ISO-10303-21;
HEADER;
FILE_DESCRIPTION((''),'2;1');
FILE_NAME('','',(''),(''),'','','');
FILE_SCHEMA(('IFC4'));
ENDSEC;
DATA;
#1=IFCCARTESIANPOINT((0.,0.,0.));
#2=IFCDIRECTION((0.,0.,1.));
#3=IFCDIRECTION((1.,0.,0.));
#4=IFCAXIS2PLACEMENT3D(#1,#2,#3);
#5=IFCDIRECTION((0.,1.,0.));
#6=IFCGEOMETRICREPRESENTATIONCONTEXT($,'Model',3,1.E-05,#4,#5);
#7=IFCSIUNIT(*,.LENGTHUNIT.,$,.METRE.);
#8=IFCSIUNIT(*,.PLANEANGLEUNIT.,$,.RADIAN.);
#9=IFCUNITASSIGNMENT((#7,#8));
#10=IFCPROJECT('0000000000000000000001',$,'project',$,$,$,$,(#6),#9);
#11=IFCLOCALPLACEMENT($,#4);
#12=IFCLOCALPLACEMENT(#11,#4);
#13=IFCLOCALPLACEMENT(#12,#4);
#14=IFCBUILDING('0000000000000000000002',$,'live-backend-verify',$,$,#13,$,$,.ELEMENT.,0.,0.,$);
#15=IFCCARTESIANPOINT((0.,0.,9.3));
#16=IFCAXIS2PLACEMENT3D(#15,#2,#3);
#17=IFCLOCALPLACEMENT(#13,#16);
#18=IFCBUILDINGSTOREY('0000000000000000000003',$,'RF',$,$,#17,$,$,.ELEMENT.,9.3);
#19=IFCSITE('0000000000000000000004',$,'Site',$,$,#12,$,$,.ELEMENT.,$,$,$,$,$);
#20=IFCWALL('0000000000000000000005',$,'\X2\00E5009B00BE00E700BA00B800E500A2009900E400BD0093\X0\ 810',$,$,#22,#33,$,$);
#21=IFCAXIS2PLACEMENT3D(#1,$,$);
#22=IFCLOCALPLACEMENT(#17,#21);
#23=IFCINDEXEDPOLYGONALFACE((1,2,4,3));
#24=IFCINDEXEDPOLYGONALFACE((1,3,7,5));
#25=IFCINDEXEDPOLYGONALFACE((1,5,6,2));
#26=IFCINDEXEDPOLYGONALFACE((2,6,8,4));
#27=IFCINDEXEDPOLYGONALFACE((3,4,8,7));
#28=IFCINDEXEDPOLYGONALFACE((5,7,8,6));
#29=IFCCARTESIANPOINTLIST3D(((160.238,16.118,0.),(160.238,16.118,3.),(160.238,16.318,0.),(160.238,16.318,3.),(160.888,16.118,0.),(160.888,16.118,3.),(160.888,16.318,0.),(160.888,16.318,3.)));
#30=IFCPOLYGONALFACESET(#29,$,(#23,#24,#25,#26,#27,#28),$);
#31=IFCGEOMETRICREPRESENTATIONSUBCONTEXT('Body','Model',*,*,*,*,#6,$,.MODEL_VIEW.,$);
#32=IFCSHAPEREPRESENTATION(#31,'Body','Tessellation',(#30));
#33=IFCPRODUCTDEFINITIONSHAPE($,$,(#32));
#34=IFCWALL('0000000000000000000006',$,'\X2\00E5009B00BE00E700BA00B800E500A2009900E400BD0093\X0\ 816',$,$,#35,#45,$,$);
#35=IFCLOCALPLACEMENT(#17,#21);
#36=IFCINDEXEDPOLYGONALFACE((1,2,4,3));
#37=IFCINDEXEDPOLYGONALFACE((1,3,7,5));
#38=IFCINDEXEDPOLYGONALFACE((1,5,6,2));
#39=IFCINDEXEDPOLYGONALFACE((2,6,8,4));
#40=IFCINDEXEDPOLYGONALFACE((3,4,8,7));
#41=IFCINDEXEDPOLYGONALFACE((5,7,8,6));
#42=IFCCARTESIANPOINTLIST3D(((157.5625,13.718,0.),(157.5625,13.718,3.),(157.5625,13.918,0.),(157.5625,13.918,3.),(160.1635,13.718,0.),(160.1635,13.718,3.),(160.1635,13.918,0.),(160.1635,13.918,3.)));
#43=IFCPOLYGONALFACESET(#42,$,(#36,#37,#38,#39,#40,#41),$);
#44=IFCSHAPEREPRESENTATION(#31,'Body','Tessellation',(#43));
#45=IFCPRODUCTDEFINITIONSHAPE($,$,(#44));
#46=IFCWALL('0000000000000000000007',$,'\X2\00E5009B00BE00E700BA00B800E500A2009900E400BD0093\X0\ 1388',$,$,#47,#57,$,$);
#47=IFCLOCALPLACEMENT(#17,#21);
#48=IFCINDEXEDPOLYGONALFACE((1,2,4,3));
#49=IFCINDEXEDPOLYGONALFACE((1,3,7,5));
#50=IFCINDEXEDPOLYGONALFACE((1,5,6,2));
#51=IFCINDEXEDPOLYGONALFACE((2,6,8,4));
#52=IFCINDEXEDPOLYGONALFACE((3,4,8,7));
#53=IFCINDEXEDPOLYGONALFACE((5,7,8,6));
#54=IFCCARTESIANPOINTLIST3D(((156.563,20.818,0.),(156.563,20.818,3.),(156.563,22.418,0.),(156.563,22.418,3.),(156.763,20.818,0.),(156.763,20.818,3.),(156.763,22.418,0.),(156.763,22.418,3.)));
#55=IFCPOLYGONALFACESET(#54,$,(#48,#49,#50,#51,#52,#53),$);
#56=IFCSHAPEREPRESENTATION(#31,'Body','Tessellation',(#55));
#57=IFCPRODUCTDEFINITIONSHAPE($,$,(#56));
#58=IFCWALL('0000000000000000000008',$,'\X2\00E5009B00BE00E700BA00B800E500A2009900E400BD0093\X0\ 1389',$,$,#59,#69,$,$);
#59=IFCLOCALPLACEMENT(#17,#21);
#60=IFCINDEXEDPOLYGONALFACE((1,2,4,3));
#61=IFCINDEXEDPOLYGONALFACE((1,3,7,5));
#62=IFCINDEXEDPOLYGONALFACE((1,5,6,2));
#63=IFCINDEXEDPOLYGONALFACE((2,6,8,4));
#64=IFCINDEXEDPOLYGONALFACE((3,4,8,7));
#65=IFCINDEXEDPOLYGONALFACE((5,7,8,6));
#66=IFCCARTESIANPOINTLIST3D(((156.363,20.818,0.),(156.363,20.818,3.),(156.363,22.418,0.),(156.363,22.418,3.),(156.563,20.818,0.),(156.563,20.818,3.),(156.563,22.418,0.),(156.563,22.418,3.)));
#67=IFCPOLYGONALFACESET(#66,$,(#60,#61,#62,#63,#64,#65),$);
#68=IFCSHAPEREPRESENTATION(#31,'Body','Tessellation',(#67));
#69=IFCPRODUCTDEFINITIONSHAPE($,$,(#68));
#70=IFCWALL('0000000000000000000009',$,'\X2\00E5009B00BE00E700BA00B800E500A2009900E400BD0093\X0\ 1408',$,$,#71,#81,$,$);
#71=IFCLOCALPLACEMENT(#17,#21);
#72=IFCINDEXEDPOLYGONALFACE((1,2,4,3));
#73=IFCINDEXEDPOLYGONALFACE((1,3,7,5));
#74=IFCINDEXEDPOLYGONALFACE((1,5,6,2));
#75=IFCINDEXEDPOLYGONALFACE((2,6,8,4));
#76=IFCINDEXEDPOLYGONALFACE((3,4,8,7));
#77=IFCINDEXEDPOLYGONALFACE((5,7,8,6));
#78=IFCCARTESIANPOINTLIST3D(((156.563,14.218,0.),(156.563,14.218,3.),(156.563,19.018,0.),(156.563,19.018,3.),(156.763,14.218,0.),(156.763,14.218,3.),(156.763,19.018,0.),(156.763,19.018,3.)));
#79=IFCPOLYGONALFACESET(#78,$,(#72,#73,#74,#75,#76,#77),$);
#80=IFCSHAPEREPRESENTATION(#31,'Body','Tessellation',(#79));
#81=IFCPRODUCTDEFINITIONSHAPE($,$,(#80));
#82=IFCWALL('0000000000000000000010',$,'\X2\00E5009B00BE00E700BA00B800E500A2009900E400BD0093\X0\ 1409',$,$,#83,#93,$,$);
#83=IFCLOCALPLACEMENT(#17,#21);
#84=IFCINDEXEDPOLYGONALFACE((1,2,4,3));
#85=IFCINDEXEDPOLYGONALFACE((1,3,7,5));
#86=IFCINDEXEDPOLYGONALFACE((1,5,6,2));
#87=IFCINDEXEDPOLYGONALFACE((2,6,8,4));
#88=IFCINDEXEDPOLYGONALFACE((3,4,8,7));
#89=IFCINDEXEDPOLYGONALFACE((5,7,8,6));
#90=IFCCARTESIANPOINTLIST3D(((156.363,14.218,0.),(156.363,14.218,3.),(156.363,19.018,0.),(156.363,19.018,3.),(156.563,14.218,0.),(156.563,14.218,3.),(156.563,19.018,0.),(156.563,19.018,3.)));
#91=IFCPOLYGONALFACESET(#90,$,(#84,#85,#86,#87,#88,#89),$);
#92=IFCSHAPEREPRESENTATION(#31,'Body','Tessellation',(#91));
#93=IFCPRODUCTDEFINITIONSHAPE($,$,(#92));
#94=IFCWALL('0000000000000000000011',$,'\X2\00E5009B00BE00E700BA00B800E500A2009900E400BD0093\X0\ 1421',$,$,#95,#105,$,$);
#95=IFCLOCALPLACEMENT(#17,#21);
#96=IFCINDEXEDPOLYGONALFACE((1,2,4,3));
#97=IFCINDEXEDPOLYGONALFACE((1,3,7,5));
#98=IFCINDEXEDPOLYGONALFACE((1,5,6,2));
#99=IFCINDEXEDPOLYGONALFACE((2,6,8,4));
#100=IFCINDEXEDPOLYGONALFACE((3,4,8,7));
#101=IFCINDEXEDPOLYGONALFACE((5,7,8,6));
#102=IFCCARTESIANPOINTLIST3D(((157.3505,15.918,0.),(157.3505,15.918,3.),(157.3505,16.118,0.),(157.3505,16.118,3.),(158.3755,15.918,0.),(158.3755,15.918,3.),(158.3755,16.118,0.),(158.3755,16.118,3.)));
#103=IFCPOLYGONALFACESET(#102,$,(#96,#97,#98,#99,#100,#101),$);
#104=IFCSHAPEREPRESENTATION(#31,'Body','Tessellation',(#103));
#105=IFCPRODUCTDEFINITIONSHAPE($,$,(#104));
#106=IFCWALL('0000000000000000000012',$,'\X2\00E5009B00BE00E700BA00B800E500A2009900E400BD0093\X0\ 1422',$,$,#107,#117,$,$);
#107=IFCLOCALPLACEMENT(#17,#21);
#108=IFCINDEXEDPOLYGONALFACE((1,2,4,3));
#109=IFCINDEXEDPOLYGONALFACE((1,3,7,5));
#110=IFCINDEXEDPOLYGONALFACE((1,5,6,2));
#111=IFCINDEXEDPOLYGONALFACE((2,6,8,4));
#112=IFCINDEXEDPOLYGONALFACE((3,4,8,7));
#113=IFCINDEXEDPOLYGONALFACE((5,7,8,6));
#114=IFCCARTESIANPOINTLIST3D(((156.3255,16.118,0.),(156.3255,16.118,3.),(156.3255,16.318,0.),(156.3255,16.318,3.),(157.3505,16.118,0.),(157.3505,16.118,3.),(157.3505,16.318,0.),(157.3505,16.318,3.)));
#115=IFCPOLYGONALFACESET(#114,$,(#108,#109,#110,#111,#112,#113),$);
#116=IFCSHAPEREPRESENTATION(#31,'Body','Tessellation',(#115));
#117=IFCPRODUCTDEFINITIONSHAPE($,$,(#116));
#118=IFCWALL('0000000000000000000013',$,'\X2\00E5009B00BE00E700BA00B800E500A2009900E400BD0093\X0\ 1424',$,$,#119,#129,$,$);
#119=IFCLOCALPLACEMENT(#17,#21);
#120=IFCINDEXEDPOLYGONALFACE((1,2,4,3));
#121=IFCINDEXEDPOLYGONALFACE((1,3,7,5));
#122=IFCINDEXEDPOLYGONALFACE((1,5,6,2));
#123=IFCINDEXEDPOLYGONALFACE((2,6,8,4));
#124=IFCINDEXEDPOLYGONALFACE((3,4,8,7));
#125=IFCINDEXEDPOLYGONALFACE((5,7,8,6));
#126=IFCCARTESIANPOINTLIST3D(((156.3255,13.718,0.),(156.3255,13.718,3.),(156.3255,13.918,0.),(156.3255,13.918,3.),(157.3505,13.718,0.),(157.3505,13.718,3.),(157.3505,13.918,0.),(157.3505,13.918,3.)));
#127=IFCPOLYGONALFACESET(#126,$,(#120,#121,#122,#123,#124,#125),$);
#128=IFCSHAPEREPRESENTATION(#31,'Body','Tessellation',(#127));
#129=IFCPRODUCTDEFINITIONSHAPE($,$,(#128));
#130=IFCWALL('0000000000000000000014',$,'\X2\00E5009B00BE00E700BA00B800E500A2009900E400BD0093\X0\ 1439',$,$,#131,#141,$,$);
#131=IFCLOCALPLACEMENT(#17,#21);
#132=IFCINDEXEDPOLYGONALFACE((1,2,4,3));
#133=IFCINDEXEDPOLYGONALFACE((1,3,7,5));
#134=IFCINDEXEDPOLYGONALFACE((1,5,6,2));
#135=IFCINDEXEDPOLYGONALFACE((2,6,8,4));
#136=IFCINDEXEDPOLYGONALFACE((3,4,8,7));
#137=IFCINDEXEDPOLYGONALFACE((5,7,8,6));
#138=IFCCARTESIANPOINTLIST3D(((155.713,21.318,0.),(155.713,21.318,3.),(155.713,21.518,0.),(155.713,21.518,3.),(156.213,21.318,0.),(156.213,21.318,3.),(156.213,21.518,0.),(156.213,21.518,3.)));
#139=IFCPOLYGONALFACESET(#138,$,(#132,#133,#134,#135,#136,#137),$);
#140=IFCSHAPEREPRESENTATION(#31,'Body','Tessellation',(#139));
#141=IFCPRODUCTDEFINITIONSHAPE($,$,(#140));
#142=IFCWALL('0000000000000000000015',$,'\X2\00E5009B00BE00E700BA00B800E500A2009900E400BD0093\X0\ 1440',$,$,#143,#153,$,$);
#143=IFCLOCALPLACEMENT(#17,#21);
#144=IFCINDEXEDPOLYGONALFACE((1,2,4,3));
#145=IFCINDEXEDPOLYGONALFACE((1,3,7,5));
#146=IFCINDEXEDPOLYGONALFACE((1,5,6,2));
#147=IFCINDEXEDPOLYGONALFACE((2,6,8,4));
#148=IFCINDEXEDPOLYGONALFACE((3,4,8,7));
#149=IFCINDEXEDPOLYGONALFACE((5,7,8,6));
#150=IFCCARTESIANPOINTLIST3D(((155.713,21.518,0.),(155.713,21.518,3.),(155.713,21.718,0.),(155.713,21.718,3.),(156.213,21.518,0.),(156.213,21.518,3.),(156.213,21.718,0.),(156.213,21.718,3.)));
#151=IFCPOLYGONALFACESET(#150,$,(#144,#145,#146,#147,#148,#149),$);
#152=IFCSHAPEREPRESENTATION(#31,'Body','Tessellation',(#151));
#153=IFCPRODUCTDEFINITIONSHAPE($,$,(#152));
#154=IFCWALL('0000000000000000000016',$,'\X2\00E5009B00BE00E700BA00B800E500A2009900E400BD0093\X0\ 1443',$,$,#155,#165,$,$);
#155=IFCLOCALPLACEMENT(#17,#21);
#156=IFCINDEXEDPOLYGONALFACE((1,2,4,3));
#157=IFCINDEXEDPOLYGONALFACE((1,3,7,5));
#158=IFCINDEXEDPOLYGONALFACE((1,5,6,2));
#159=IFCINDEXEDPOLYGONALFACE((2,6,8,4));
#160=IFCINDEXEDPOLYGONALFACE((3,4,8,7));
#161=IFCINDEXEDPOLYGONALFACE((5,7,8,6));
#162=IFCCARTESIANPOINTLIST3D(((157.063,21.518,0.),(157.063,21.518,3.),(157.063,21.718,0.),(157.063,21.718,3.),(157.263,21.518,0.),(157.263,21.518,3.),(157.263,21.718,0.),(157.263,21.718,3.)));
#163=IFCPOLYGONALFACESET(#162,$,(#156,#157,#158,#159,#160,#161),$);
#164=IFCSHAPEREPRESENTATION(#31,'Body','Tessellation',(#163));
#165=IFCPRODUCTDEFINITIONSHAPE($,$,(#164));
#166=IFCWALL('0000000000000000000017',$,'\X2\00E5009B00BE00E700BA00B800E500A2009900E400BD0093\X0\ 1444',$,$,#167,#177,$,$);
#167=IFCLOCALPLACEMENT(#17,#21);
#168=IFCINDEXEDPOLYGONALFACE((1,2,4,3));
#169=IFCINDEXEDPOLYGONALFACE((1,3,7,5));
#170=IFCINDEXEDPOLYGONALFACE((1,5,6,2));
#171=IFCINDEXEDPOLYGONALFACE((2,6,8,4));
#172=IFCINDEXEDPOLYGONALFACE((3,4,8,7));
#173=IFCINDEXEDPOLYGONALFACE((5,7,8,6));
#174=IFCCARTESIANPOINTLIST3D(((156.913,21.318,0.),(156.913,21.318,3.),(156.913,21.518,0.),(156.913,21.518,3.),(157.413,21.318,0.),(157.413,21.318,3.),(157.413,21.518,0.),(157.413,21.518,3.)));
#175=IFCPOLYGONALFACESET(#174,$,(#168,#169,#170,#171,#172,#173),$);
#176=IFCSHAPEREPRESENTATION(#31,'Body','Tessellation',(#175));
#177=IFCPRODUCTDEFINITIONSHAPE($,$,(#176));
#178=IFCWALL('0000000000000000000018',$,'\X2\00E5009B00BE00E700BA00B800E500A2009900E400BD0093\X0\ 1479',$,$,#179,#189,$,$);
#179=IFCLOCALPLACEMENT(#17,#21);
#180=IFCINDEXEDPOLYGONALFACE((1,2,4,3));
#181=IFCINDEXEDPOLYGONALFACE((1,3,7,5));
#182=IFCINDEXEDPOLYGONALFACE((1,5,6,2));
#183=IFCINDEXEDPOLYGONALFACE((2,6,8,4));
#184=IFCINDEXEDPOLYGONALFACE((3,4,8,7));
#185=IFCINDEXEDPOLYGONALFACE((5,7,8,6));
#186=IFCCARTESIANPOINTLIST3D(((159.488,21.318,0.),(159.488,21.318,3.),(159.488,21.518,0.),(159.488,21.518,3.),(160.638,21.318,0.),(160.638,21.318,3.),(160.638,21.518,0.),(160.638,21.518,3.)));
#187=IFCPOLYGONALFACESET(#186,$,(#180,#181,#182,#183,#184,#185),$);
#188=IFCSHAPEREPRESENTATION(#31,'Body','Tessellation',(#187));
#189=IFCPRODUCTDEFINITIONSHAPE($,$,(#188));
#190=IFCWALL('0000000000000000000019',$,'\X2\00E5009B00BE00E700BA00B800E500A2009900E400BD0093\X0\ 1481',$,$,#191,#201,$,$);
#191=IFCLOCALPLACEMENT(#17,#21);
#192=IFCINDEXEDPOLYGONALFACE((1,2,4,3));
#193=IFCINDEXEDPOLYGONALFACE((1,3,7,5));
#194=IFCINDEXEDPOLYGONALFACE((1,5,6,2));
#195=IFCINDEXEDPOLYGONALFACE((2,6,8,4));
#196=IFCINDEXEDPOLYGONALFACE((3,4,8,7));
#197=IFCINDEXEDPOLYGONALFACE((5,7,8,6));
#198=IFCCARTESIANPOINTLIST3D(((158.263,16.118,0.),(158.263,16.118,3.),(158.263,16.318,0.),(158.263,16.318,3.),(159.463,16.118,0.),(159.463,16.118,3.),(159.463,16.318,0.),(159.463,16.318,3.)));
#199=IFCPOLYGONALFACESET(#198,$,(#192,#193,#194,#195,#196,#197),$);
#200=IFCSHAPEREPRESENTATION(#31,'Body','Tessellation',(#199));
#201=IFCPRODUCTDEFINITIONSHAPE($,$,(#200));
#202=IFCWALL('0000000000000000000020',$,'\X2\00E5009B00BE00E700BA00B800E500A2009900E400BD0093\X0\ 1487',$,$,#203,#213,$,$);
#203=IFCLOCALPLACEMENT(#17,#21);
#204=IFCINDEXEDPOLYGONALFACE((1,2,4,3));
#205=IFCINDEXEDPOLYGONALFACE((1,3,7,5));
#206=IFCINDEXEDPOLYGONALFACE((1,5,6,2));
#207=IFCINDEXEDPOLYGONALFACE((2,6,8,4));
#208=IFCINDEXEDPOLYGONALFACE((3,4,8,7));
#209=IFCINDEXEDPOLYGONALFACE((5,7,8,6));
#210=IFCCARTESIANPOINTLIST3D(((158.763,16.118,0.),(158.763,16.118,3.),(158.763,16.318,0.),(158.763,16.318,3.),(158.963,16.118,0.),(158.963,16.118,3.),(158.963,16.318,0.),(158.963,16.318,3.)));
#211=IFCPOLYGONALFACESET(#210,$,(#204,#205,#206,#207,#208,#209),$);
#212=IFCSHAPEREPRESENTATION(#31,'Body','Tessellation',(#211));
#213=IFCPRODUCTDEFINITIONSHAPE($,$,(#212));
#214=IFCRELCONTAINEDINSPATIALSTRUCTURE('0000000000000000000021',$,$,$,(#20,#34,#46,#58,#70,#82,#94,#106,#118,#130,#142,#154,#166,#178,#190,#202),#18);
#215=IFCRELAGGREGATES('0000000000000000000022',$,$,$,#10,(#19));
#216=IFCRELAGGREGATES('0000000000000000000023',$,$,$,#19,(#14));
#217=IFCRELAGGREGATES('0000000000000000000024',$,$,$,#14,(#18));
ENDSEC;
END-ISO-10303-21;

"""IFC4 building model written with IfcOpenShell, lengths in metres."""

from ifc_helpers import new_model, si_unit, direction, frame, frame_2d, origin_with_axes, place, context, subcontext, project, spatial, rectangle, extrude, element, save


model = new_model("IFC4")

# Units and contexts
model_context = context("Model", 3, precision=1e-05, world=origin_with_axes(), true_north=direction((0.0, 1.0, 0.0)))
body_context = subcontext(model_context, "Body", "Model", "MODEL_VIEW")
ifc_project = project(units=[si_unit("LENGTHUNIT", "METRE"), si_unit("PLANEANGLEUNIT", "RADIAN")], contexts=[model_context])

# Site, building, storey
placement = place(None, origin_with_axes())
site_placement = place(placement, origin_with_axes())
site = spatial("IfcSite", under=ifc_project, at=site_placement, Name="Site", CompositionType="ELEMENT")
building_placement = place(site_placement, origin_with_axes())
building = spatial("IfcBuilding", under=site, at=building_placement, Name="live-backend-verify", CompositionType="ELEMENT", ElevationOfRefHeight=0.0, ElevationOfTerrain=0.0)
storey_placement = place(building_placement, frame((0.0, 0.0, 9.3), z_axis=(0.0, 0.0, 1.0), x_axis=(1.0, 0.0, 0.0)))
storey = spatial("IfcBuildingStorey", under=building, at=storey_placement, Name="RF", CompositionType="ELEMENT", Elevation=9.3)

# Walls
wall_1_placement = place(storey_placement, frame((160.563, 16.218, 0.0), z_axis=(0.0, 0.0, 1.0), x_axis=(1.0, 0.0, 0.0)))
element("IfcWall", 1, at=wall_1_placement, inside=storey, Name="å\u009b¾çº¸å¢\u0099ä½\u0093 810", context=body_context, shape_type="SweptSolid", body=[
    extrude(rectangle(XDim=0.65, YDim=0.2, at=frame_2d((0.0, 0.0), x_axis=(1.0, 0.0, 0.0))), frame((0.0, 0.0, 0.0), z_axis=(0.0, 0.0, 1.0)), (0.0, 0.0, 1.0), 3.0),
])
wall_2_placement = place(storey_placement, frame((158.863, 13.818, 0.0), z_axis=(0.0, 0.0, 1.0), x_axis=(1.0, 0.0, 0.0)))
element("IfcWall", 2, at=wall_2_placement, inside=storey, Name="å\u009b¾çº¸å¢\u0099ä½\u0093 816", context=body_context, shape_type="SweptSolid", body=[
    extrude(rectangle(XDim=2.601, YDim=0.2, at=frame_2d((0.0, 0.0), x_axis=(1.0, 0.0, 0.0))), frame((0.0, 0.0, 0.0), z_axis=(0.0, 0.0, 1.0)), (0.0, 0.0, 1.0), 3.0),
])
for number, where, z_axis, x_axis, name in (
    (3, (156.663, 21.618, 0.0), (0.0, 0.0, 1.0), (0.0, 1.0, 0.0), "å\u009b¾çº¸å¢\u0099ä½\u0093 1388"),
    (4, (156.463, 21.618, 0.0), (0.0, 0.0, 1.0), (0.0, 1.0, 0.0), "å\u009b¾çº¸å¢\u0099ä½\u0093 1389"),
):
    element("IfcWall", number, at=place(storey_placement, frame(where, z_axis=z_axis, x_axis=x_axis)), inside=storey, Name=name, context=body_context, shape_type="SweptSolid", body=[
        extrude(rectangle(XDim=1.6, YDim=0.2, at=frame_2d((0.0, 0.0), x_axis=(1.0, 0.0, 0.0))), frame((0.0, 0.0, 0.0), z_axis=(0.0, 0.0, 1.0)), (0.0, 0.0, 1.0), 3.0),
    ])
for number, where, z_axis, x_axis, name in (
    (5, (156.663, 16.618, 0.0), (0.0, 0.0, 1.0), (0.0, 1.0, 0.0), "å\u009b¾çº¸å¢\u0099ä½\u0093 1408"),
    (6, (156.463, 16.618, 0.0), (0.0, 0.0, 1.0), (0.0, 1.0, 0.0), "å\u009b¾çº¸å¢\u0099ä½\u0093 1409"),
):
    element("IfcWall", number, at=place(storey_placement, frame(where, z_axis=z_axis, x_axis=x_axis)), inside=storey, Name=name, context=body_context, shape_type="SweptSolid", body=[
        extrude(rectangle(XDim=4.8, YDim=0.2, at=frame_2d((0.0, 0.0), x_axis=(1.0, 0.0, 0.0))), frame((0.0, 0.0, 0.0), z_axis=(0.0, 0.0, 1.0)), (0.0, 0.0, 1.0), 3.0),
    ])
for number, where, z_axis, x_axis, name in (
    (7, (157.863, 16.018, 0.0), (0.0, 0.0, 1.0), (-1.0, 0.0, 0.0), "å\u009b¾çº¸å¢\u0099ä½\u0093 1421"),
    (8, (156.838, 16.218, 0.0), (0.0, 0.0, 1.0), (1.0, 0.0, 0.0), "å\u009b¾çº¸å¢\u0099ä½\u0093 1422"),
    (9, (156.838, 13.818, 0.0), (0.0, 0.0, 1.0), (1.0, 0.0, 0.0), "å\u009b¾çº¸å¢\u0099ä½\u0093 1424"),
):
    element("IfcWall", number, at=place(storey_placement, frame(where, z_axis=z_axis, x_axis=x_axis)), inside=storey, Name=name, context=body_context, shape_type="SweptSolid", body=[
        extrude(rectangle(XDim=1.025, YDim=0.2, at=frame_2d((0.0, 0.0), x_axis=(1.0, 0.0, 0.0))), frame((0.0, 0.0, 0.0), z_axis=(0.0, 0.0, 1.0)), (0.0, 0.0, 1.0), 3.0),
    ])
for number, where, z_axis, x_axis, name in (
    (10, (155.963, 21.418, 0.0), (0.0, 0.0, 1.0), (1.0, 0.0, 0.0), "å\u009b¾çº¸å¢\u0099ä½\u0093 1439"),
    (11, (155.963, 21.618, 0.0), (0.0, 0.0, 1.0), (1.0, 0.0, 0.0), "å\u009b¾çº¸å¢\u0099ä½\u0093 1440"),
):
    element("IfcWall", number, at=place(storey_placement, frame(where, z_axis=z_axis, x_axis=x_axis)), inside=storey, Name=name, context=body_context, shape_type="SweptSolid", body=[
        extrude(rectangle(XDim=0.5, YDim=0.2, at=frame_2d((0.0, 0.0), x_axis=(1.0, 0.0, 0.0))), frame((0.0, 0.0, 0.0), z_axis=(0.0, 0.0, 1.0)), (0.0, 0.0, 1.0), 3.0),
    ])
wall_3_placement = place(storey_placement, frame((157.163, 21.618, 0.0), z_axis=(0.0, 0.0, 1.0), x_axis=(0.0, -1.0, 0.0)))
element("IfcWall", 12, at=wall_3_placement, inside=storey, Name="å\u009b¾çº¸å¢\u0099ä½\u0093 1443", context=body_context, shape_type="SweptSolid", body=[
    extrude(rectangle(XDim=0.2, YDim=0.2, at=frame_2d((0.0, 0.0), x_axis=(1.0, 0.0, 0.0))), frame((0.0, 0.0, 0.0), z_axis=(0.0, 0.0, 1.0)), (0.0, 0.0, 1.0), 3.0),
])
wall_4_placement = place(storey_placement, frame((157.163, 21.418, 0.0), z_axis=(0.0, 0.0, 1.0), x_axis=(-1.0, 0.0, 0.0)))
element("IfcWall", 13, at=wall_4_placement, inside=storey, Name="å\u009b¾çº¸å¢\u0099ä½\u0093 1444", context=body_context, shape_type="SweptSolid", body=[
    extrude(rectangle(XDim=0.5, YDim=0.2, at=frame_2d((0.0, 0.0), x_axis=(1.0, 0.0, 0.0))), frame((0.0, 0.0, 0.0), z_axis=(0.0, 0.0, 1.0)), (0.0, 0.0, 1.0), 3.0),
])
wall_5_placement = place(storey_placement, frame((160.063, 21.418, 0.0), z_axis=(0.0, 0.0, 1.0), x_axis=(-1.0, 0.0, 0.0)))
element("IfcWall", 14, at=wall_5_placement, inside=storey, Name="å\u009b¾çº¸å¢\u0099ä½\u0093 1479", context=body_context, shape_type="SweptSolid", body=[
    extrude(rectangle(XDim=1.15, YDim=0.2, at=frame_2d((0.0, 0.0), x_axis=(1.0, 0.0, 0.0))), frame((0.0, 0.0, 0.0), z_axis=(0.0, 0.0, 1.0)), (0.0, 0.0, 1.0), 3.0),
])
wall_6_placement = place(storey_placement, frame((158.863, 16.218, 0.0), z_axis=(0.0, 0.0, 1.0), x_axis=(1.0, 0.0, 0.0)))
element("IfcWall", 15, at=wall_6_placement, inside=storey, Name="å\u009b¾çº¸å¢\u0099ä½\u0093 1481", context=body_context, shape_type="SweptSolid", body=[
    extrude(rectangle(XDim=1.2, YDim=0.2, at=frame_2d((0.0, 0.0), x_axis=(1.0, 0.0, 0.0))), frame((0.0, 0.0, 0.0), z_axis=(0.0, 0.0, 1.0)), (0.0, 0.0, 1.0), 3.0),
])
for number, where, z_axis, x_axis, name in (
    (16, (158.863, 16.218, 0.0), (0.0, 0.0, 1.0), (0.0, -1.0, 0.0), "å\u009b¾çº¸å¢\u0099ä½\u0093 1487"),
):
    element("IfcWall", number, at=place(storey_placement, frame(where, z_axis=z_axis, x_axis=x_axis)), inside=storey, Name=name, context=body_context, shape_type="SweptSolid", body=[
        extrude(rectangle(XDim=0.2, YDim=0.2, at=frame_2d((0.0, 0.0), x_axis=(1.0, 0.0, 0.0))), frame((0.0, 0.0, 0.0), z_axis=(0.0, 0.0, 1.0)), (0.0, 0.0, 1.0), 3.0),
    ])

save(model, "model.ifc")
